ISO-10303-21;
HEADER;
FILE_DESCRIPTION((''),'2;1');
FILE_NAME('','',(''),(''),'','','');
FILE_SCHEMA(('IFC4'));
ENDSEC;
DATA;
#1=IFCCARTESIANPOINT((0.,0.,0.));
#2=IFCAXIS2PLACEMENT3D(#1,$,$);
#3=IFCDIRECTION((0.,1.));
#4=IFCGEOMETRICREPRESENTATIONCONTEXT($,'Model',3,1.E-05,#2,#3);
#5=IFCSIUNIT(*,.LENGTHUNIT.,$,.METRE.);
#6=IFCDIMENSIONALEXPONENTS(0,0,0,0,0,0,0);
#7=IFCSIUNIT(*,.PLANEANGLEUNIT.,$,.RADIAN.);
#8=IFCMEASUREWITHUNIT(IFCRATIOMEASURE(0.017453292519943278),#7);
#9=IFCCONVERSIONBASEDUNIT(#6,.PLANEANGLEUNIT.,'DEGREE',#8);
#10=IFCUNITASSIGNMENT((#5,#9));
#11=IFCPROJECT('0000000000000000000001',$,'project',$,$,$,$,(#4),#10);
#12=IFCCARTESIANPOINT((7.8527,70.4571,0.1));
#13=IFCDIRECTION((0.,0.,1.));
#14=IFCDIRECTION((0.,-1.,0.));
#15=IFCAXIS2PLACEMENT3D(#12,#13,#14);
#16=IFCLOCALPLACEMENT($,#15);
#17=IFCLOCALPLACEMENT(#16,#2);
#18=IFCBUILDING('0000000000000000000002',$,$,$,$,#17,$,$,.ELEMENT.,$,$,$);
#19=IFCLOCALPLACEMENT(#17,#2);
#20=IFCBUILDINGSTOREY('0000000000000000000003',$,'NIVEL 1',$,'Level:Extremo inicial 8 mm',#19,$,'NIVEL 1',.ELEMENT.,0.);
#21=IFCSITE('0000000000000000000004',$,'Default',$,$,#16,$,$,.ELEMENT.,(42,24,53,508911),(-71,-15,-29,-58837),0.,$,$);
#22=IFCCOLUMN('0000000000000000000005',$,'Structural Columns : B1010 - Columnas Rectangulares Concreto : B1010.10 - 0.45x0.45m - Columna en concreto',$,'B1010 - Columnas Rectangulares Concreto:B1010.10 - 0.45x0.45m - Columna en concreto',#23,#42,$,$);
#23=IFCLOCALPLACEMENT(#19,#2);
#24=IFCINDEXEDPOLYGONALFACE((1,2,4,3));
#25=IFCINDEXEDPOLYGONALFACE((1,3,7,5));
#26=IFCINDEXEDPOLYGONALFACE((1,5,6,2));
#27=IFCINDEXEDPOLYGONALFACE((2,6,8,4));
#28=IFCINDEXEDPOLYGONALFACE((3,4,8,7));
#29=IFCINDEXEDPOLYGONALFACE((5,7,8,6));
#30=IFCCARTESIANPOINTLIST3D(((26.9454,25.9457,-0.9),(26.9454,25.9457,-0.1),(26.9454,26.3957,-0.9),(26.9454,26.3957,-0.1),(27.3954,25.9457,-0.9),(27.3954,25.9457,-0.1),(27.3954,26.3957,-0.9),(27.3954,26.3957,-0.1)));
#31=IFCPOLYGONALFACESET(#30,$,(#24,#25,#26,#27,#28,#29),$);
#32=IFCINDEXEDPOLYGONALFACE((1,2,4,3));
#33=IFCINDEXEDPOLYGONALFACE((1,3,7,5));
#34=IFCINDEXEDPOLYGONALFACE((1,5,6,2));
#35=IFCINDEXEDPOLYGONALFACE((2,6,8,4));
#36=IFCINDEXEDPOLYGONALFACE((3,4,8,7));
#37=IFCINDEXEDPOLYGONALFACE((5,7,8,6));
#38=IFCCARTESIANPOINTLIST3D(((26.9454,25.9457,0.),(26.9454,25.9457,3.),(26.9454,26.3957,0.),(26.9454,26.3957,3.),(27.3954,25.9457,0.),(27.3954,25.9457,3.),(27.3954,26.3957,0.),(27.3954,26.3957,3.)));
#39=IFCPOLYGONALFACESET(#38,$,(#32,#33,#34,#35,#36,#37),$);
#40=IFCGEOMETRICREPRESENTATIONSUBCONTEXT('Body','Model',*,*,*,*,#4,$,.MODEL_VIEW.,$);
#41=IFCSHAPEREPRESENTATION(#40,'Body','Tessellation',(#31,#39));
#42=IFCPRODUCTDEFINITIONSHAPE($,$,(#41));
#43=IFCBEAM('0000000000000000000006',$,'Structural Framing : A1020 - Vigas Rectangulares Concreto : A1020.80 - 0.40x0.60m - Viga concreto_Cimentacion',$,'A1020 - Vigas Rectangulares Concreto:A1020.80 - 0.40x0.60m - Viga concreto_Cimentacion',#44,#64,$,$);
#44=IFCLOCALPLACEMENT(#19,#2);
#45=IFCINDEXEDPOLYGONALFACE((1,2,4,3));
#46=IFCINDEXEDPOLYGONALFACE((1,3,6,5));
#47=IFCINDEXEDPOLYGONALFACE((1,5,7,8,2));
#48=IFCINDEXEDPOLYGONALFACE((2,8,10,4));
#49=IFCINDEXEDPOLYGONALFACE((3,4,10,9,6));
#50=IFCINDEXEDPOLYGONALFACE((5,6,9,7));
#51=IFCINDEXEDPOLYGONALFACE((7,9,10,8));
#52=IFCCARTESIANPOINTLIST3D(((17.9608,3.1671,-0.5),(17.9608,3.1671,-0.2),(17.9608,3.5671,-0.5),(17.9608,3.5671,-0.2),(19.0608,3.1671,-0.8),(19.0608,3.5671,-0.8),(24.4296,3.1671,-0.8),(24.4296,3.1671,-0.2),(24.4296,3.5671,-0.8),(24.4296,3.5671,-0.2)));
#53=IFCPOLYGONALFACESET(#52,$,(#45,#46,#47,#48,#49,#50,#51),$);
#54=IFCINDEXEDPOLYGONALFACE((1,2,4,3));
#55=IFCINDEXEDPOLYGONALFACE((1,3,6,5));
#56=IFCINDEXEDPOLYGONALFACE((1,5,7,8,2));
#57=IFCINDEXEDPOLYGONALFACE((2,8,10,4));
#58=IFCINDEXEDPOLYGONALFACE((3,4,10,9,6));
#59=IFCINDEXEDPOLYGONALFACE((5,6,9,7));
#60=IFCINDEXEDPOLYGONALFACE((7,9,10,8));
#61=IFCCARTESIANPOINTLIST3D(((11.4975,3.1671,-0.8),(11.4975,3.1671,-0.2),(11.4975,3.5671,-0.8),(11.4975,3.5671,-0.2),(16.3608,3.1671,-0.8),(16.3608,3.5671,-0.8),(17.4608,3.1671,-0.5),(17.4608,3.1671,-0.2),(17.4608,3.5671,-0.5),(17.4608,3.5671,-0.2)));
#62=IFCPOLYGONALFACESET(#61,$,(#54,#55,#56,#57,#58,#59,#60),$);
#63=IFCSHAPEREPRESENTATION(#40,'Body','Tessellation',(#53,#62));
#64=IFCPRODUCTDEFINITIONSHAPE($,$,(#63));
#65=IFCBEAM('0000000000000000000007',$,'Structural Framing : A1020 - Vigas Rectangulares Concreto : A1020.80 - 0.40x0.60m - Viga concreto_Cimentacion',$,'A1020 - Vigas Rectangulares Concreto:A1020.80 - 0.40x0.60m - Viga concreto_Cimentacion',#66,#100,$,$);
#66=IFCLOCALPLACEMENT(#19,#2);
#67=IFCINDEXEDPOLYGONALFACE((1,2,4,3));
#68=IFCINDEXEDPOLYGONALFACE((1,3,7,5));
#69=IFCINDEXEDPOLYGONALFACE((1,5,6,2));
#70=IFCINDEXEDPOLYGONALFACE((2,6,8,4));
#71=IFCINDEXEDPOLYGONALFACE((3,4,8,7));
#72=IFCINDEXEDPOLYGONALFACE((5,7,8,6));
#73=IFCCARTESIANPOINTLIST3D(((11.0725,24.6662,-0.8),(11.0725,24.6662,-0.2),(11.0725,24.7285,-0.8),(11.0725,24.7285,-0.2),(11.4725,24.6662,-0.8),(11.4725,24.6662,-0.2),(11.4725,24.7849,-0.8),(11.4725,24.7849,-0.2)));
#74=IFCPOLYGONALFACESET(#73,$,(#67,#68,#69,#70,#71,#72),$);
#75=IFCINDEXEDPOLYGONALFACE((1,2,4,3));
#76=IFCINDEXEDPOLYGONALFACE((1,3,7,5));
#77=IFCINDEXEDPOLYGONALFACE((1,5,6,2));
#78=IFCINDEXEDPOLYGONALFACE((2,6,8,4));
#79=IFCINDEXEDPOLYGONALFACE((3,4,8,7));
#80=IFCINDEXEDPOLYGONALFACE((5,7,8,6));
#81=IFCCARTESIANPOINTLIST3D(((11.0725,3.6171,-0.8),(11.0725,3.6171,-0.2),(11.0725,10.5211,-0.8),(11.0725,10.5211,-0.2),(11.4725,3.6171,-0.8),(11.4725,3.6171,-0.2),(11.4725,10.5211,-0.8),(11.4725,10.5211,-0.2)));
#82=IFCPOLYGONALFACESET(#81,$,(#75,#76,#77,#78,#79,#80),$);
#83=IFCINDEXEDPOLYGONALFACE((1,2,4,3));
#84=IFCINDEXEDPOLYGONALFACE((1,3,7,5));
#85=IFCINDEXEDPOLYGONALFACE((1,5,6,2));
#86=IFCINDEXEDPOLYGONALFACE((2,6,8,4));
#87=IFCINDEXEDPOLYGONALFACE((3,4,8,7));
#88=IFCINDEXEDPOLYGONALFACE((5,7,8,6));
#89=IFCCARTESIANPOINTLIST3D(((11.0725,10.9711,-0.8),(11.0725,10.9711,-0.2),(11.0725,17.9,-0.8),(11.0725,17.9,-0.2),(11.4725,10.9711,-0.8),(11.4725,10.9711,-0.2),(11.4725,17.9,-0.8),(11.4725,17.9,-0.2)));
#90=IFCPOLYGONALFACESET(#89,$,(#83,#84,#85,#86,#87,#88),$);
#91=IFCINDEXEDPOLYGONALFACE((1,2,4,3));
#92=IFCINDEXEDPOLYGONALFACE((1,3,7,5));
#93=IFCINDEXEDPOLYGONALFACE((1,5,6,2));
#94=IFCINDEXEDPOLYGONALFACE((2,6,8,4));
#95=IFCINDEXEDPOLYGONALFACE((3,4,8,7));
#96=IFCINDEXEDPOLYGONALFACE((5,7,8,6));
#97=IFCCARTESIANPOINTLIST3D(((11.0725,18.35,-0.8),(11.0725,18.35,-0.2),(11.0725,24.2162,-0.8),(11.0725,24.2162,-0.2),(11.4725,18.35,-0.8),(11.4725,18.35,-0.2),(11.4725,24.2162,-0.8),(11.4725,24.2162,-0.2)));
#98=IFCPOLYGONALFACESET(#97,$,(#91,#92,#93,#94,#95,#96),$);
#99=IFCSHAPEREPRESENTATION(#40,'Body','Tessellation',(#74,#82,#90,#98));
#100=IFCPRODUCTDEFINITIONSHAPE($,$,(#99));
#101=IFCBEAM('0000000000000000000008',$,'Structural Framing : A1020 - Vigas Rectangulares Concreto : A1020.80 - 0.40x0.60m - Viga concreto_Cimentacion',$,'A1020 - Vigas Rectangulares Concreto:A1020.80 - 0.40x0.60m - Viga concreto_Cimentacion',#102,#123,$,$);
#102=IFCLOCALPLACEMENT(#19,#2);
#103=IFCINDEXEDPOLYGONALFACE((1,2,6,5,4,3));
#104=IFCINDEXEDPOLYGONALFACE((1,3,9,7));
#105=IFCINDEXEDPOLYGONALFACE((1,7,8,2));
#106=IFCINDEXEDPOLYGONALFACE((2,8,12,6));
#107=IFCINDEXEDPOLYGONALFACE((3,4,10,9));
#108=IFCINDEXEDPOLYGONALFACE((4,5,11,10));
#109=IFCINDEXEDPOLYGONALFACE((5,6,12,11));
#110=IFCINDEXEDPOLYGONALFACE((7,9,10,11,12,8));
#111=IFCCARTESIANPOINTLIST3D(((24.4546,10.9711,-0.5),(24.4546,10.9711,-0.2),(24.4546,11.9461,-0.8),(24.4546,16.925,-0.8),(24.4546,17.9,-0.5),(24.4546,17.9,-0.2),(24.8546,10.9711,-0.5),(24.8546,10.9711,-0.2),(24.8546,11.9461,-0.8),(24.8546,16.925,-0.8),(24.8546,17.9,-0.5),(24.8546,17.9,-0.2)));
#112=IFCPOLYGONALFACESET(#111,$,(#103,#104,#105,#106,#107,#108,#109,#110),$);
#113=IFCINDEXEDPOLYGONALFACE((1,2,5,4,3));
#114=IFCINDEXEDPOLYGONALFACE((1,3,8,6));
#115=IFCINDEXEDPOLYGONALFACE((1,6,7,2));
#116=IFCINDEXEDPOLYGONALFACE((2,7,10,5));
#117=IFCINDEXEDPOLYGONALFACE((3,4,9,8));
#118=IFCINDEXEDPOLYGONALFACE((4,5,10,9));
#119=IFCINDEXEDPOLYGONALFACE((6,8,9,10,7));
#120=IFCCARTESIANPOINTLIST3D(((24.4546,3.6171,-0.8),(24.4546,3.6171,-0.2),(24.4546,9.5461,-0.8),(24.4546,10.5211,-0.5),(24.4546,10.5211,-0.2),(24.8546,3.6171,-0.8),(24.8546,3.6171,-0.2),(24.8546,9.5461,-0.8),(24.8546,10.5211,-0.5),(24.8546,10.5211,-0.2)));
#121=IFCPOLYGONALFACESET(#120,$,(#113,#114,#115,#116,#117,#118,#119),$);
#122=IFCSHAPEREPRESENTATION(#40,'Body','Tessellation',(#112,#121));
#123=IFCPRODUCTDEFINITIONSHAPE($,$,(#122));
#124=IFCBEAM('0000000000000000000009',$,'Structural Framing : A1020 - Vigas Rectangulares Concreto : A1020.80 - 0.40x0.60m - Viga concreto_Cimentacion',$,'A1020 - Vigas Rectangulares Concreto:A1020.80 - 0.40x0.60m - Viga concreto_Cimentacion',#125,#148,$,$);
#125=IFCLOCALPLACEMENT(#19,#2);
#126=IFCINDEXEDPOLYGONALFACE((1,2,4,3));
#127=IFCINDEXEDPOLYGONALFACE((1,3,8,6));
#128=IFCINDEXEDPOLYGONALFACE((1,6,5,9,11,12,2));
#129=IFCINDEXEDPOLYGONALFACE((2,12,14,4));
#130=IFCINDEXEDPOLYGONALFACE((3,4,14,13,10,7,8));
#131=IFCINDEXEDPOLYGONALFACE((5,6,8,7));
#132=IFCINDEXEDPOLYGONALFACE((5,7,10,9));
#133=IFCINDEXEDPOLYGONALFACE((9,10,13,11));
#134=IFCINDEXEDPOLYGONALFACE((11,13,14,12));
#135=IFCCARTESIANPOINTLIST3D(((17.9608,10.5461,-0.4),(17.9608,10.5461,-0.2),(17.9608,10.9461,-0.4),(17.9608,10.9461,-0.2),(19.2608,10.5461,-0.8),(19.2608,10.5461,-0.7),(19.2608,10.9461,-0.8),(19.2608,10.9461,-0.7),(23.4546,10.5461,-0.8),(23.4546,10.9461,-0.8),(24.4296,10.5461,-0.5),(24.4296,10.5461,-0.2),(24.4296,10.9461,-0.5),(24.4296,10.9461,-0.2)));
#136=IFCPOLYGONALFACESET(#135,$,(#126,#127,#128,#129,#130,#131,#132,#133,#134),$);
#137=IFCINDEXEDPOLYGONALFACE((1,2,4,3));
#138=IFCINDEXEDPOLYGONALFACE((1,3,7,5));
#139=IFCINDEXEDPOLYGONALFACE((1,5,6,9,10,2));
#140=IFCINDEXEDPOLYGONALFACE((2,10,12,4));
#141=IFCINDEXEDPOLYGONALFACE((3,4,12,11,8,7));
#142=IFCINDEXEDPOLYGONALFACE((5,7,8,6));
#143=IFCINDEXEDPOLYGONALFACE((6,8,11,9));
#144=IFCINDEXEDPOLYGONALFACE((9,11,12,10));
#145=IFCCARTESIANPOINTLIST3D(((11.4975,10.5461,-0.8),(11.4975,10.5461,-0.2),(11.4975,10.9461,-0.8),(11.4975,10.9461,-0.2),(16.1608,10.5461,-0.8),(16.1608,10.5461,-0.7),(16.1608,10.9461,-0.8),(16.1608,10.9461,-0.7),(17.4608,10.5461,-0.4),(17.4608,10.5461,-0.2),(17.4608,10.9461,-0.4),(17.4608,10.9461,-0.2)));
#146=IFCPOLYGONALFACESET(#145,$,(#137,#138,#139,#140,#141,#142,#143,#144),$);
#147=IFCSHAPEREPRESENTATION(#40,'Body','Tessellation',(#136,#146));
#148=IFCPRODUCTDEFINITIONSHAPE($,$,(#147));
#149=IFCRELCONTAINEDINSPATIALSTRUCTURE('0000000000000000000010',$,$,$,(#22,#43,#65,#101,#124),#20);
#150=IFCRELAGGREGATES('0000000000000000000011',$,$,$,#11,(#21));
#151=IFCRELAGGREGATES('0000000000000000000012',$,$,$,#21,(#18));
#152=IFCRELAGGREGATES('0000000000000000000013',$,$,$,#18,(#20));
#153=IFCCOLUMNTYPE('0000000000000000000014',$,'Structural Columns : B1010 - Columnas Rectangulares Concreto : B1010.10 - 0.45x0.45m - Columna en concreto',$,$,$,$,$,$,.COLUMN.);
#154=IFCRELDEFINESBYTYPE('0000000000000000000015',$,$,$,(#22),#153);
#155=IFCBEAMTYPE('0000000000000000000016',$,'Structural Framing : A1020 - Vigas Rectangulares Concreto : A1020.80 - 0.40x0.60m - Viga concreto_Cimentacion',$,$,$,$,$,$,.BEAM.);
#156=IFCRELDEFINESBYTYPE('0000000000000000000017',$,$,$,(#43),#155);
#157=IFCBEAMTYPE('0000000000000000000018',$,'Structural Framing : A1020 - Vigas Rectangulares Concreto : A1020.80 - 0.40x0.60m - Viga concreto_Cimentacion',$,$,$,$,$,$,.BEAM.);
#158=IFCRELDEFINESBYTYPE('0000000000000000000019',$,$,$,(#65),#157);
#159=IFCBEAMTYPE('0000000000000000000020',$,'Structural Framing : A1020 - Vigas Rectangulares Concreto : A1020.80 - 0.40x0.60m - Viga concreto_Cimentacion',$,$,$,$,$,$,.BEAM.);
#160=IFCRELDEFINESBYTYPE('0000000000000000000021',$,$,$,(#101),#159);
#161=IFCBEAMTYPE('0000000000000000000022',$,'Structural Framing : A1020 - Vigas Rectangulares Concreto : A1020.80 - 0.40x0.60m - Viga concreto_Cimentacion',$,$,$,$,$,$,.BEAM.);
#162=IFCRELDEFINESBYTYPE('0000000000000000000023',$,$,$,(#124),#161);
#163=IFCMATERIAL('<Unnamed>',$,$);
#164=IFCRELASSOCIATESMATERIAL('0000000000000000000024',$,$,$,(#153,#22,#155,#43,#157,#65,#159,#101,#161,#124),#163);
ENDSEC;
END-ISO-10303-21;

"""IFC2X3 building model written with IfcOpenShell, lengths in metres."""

from ifc_helpers import new_model, entity, si_unit, converted_unit, direction, frame, frame_2d, origin, origin_2d_with_axis, place, context, subcontext, project, spatial, polyline, rectangle, extrude, clip, halfspace, bounded_halfspace, source, transform, mapped, material, type_object, type_shapes, element, save


model = new_model("IFC2X3")

# Units and contexts
model_context = context("Model", 3, precision=1e-05, world=origin(), true_north=direction((0.0, 1.0)))
body_context = subcontext(model_context, "Body", "Model", "MODEL_VIEW")
ifc_project = project(units=[si_unit("LENGTHUNIT", "METRE"), converted_unit("PLANEANGLEUNIT", "DEGREE", entity("IfcRatioMeasure", 0.017453292519943278), si_unit("PLANEANGLEUNIT", "RADIAN"), dimensions=[0, 0, 0, 0, 0, 0, 0])], contexts=[model_context])

# Site, building, storey
site_placement = place(None, frame((7.8527, 70.4571, 0.1), z_axis=(0.0, 0.0, 1.0), x_axis=(0.0, -1.0, 0.0)))
site = spatial("IfcSite", under=ifc_project, at=site_placement, Name="Default", CompositionType="ELEMENT", RefLatitude=(42, 24, 53, 508911), RefLongitude=(-71, -15, -29, -58837), RefElevation=0.0)
building_placement = place(site_placement, origin())
building = spatial("IfcBuilding", under=site, at=building_placement, CompositionType="ELEMENT")
storey_placement = place(building_placement, origin())
storey = spatial("IfcBuildingStorey", under=building, at=storey_placement, Name="NIVEL 1", ObjectType="Level:Extremo inicial 8 mm", LongName="NIVEL 1", CompositionType="ELEMENT", Elevation=0.0)

# Column
ifc_material_1 = material(Name="<Unnamed>")
column_type = type_object("IfcColumnType", Name="Structural Columns : B1010 - Columnas Rectangulares Concreto : B1010.10 - 0.45x0.45m - Columna en concreto", PredefinedType="COLUMN", material=ifc_material_1)
shared_shape_1 = source(origin(), body_context, "Body", "SweptSolid", [
    extrude(rectangle(XDim=0.45, YDim=0.45, at=origin_2d_with_axis()), frame((27.1704, 26.1707, -0.9), z_axis=(0.0, 0.0, 1.0), x_axis=(0.0, -1.0, 0.0)), (0.0, 0.0, 1.0), 0.8),
    extrude(rectangle(XDim=0.45, YDim=0.45, at=origin_2d_with_axis()), frame((27.1704, 26.1707, 0.0), z_axis=(0.0, 0.0, 1.0), x_axis=(0.0, -1.0, 0.0)), (0.0, 0.0, 1.0), 3.0),
])
type_shapes(column_type, [shared_shape_1])
column_placement = place(storey_placement, origin())
element("IfcColumn", 1, at=column_placement, inside=storey, type_object=column_type, material=ifc_material_1, Name="Structural Columns : B1010 - Columnas Rectangulares Concreto : B1010.10 - 0.45x0.45m - Columna en concreto", ObjectType="B1010 - Columnas Rectangulares Concreto:B1010.10 - 0.45x0.45m - Columna en concreto", context=body_context, shape_type="MappedRepresentation", body=[
    mapped(shared_shape_1, transform((0.0, 0.0, 0.0), scale=1.0)),
])

# Beams
beam_type_1 = type_object("IfcBeamType", Name="Structural Framing : A1020 - Vigas Rectangulares Concreto : A1020.80 - 0.40x0.60m - Viga concreto_Cimentacion", PredefinedType="BEAM", material=ifc_material_1)
shared_shape_2 = source(origin(), body_context, "Body", "SweptSolid", [
    clip(extrude(rectangle(XDim=0.6, YDim=0.4, at=frame_2d((0.0, 0.0), x_axis=(0.0, 1.0))), frame((17.9608, 3.3671, -0.5), z_axis=(1.0, 0.0, 0.0), x_axis=(0.0, 1.0, 0.0)), (0.0, 0.0, 1.0), 6.4688), halfspace(frame((19.0608, 3.3671, -0.8), z_axis=(-0.263117, 0.0, -0.964764), x_axis=(0.0, 1.0, 0.0)), False)),
    clip(extrude(rectangle(XDim=0.6, YDim=0.4, at=frame_2d((0.0, 0.0), x_axis=(0.0, 1.0))), frame((11.4975, 3.3671, -0.5), z_axis=(1.0, 0.0, 0.0), x_axis=(0.0, 1.0, 0.0)), (0.0, 0.0, 1.0), 5.9633), halfspace(frame((16.3608, 3.3671, -0.8), z_axis=(0.263117, 0.0, -0.964764), x_axis=(0.0, -1.0, 0.0)), False)),
])
type_shapes(beam_type_1, [shared_shape_2])
beam_1_placement = place(storey_placement, origin())
element("IfcBeam", 2, at=beam_1_placement, inside=storey, type_object=beam_type_1, material=ifc_material_1, Name="Structural Framing : A1020 - Vigas Rectangulares Concreto : A1020.80 - 0.40x0.60m - Viga concreto_Cimentacion", ObjectType="A1020 - Vigas Rectangulares Concreto:A1020.80 - 0.40x0.60m - Viga concreto_Cimentacion", context=body_context, shape_type="MappedRepresentation", body=[
    mapped(shared_shape_2, transform((0.0, 0.0, 0.0), scale=1.0)),
])
beam_type_2 = type_object("IfcBeamType", Name="Structural Framing : A1020 - Vigas Rectangulares Concreto : A1020.80 - 0.40x0.60m - Viga concreto_Cimentacion", PredefinedType="BEAM", material=ifc_material_1)
shared_shape_3 = source(origin(), body_context, "Body", "SweptSolid", [
    clip(extrude(rectangle(XDim=0.6, YDim=0.4, at=frame_2d((0.0, 0.0), x_axis=(0.0, 1.0))), frame((11.2725, 24.6662, -0.5), z_axis=(0.0, 1.0, 0.0), x_axis=(-1.0, 0.0, 0.0)), (0.0, 0.0, 1.0), 0.1187), halfspace(frame((10.9962, 24.7178, -0.2), z_axis=(-0.139655, 0.9902, 0.0), x_axis=(0.9902, 0.139655, 0.0)), False)),
    extrude(rectangle(XDim=0.6, YDim=0.4, at=frame_2d((0.0, 0.0), x_axis=(0.0, 1.0))), frame((11.2725, 3.6171, -0.5), z_axis=(0.0, 1.0, 0.0), x_axis=(-1.0, 0.0, 0.0)), (0.0, 0.0, 1.0), 6.904),
    extrude(rectangle(XDim=0.6, YDim=0.4, at=frame_2d((0.0, 0.0), x_axis=(0.0, 1.0))), frame((11.2725, 10.9711, -0.5), z_axis=(0.0, 1.0, 0.0), x_axis=(-1.0, 0.0, 0.0)), (0.0, 0.0, 1.0), 6.929),
    extrude(rectangle(XDim=0.6, YDim=0.4, at=frame_2d((0.0, 0.0), x_axis=(0.0, 1.0))), frame((11.2725, 18.35, -0.5), z_axis=(0.0, 1.0, 0.0), x_axis=(-1.0, 0.0, 0.0)), (0.0, 0.0, 1.0), 5.8662),
])
type_shapes(beam_type_2, [shared_shape_3])
beam_2_placement = place(storey_placement, origin())
element("IfcBeam", 3, at=beam_2_placement, inside=storey, type_object=beam_type_2, material=ifc_material_1, Name="Structural Framing : A1020 - Vigas Rectangulares Concreto : A1020.80 - 0.40x0.60m - Viga concreto_Cimentacion", ObjectType="A1020 - Vigas Rectangulares Concreto:A1020.80 - 0.40x0.60m - Viga concreto_Cimentacion", context=body_context, shape_type="MappedRepresentation", body=[
    mapped(shared_shape_3, transform((0.0, 0.0, 0.0), scale=1.0)),
])
beam_type_3 = type_object("IfcBeamType", Name="Structural Framing : A1020 - Vigas Rectangulares Concreto : A1020.80 - 0.40x0.60m - Viga concreto_Cimentacion", PredefinedType="BEAM", material=ifc_material_1)
shared_shape_4 = source(origin(), body_context, "Body", "SweptSolid", [
    clip(clip(extrude(rectangle(XDim=0.6, YDim=0.4, at=frame_2d((0.0, 0.0), x_axis=(0.0, 1.0))), frame((24.6546, 10.9711, -0.5), z_axis=(0.0, 1.0, 0.0), x_axis=(-1.0, 0.0, 0.0)), (0.0, 0.0, 1.0), 6.929), halfspace(frame((24.6546, 11.9461, -0.8), z_axis=(0.0, -0.294086, -0.955779), x_axis=(-1.0, 0.0, 0.0)), False)), halfspace(frame((24.6546, 16.925, -0.8), z_axis=(0.0, 0.294086, -0.955779), x_axis=(1.0, 0.0, 0.0)), False)),
    clip(extrude(rectangle(XDim=0.6, YDim=0.4, at=frame_2d((0.0, 0.0), x_axis=(0.0, 1.0))), frame((24.6546, 3.6171, -0.5), z_axis=(0.0, 1.0, 0.0), x_axis=(-1.0, 0.0, 0.0)), (0.0, 0.0, 1.0), 6.904), halfspace(frame((24.6546, 9.5461, -0.8), z_axis=(0.0, 0.294086, -0.955779), x_axis=(1.0, 0.0, 0.0)), False)),
])
type_shapes(beam_type_3, [shared_shape_4])
beam_3_placement = place(storey_placement, origin())
element("IfcBeam", 4, at=beam_3_placement, inside=storey, type_object=beam_type_3, material=ifc_material_1, Name="Structural Framing : A1020 - Vigas Rectangulares Concreto : A1020.80 - 0.40x0.60m - Viga concreto_Cimentacion", ObjectType="A1020 - Vigas Rectangulares Concreto:A1020.80 - 0.40x0.60m - Viga concreto_Cimentacion", context=body_context, shape_type="MappedRepresentation", body=[
    mapped(shared_shape_4, transform((0.0, 0.0, 0.0), scale=1.0)),
])
beam_type_4 = type_object("IfcBeamType", Name="Structural Framing : A1020 - Vigas Rectangulares Concreto : A1020.80 - 0.40x0.60m - Viga concreto_Cimentacion", PredefinedType="BEAM", material=ifc_material_1)
shared_shape_5 = source(origin(), body_context, "Body", "SweptSolid", [
    clip(clip(clip(extrude(rectangle(XDim=0.6, YDim=0.4, at=frame_2d((0.0, 0.0), x_axis=(0.0, 1.0))), frame((17.9608, 10.7461, -0.5), z_axis=(1.0, 0.0, 0.0), x_axis=(0.0, 1.0, 0.0)), (0.0, 0.0, 1.0), 6.4688), halfspace(frame((23.4546, 10.7461, -0.8), z_axis=(0.294086, 0.0, -0.955779), x_axis=(0.0, -1.0, 0.0)), False)), bounded_halfspace(frame((19.2608, 10.7461, -0.7), z_axis=(-0.22486, 0.0, -0.974391), x_axis=(0.0, 1.0, 0.0)), False, frame((17.9608, 10.7461, -0.5), z_axis=(1.0, 0.0, 0.0), x_axis=(0.0, 1.0, 0.0)), polyline([(-0.2, -0.2), (-0.2, 0.1), (0.2, 0.1), (0.2, -0.2), (-0.2, -0.2)]))), bounded_halfspace(frame((19.2608, 9.1961, -0.7), z_axis=(-1.0, 0.0, 0.0), x_axis=(0.0, 0.0, -1.0)), False, frame((17.9608, 10.7461, -0.5), z_axis=(1.0, 0.0, 0.0), x_axis=(0.0, 1.0, 0.0)), polyline([(-0.2, -0.3), (-0.2, -0.2), (0.2, -0.2), (0.2, -0.3), (-0.2, -0.3)]))),
    clip(clip(extrude(rectangle(XDim=0.6, YDim=0.4, at=frame_2d((0.0, 0.0), x_axis=(0.0, 1.0))), frame((11.4975, 10.7461, -0.5), z_axis=(1.0, 0.0, 0.0), x_axis=(0.0, 1.0, 0.0)), (0.0, 0.0, 1.0), 5.9633), bounded_halfspace(frame((16.1608, 10.7461, -0.7), z_axis=(0.22486, 0.0, -0.974391), x_axis=(0.0, -1.0, 0.0)), False, frame((11.4975, 10.7461, -0.5), z_axis=(1.0, 0.0, 0.0), x_axis=(0.0, 1.0, 0.0)), polyline([(-0.2, 0.1), (-0.2, -0.2), (0.2, -0.2), (0.2, 0.1), (-0.2, 0.1)]))), bounded_halfspace(frame((16.1608, 12.2961, -0.7), z_axis=(1.0, 0.0, 0.0), x_axis=(0.0, 0.0, -1.0)), False, frame((11.4975, 10.7461, -0.5), z_axis=(1.0, 0.0, 0.0), x_axis=(0.0, 1.0, 0.0)), polyline([(-0.2, -0.2), (-0.2, -0.3), (0.2, -0.3), (0.2, -0.2), (-0.2, -0.2)]))),
])
type_shapes(beam_type_4, [shared_shape_5])
beam_4_placement = place(storey_placement, origin())
element("IfcBeam", 5, at=beam_4_placement, inside=storey, type_object=beam_type_4, material=ifc_material_1, Name="Structural Framing : A1020 - Vigas Rectangulares Concreto : A1020.80 - 0.40x0.60m - Viga concreto_Cimentacion", ObjectType="A1020 - Vigas Rectangulares Concreto:A1020.80 - 0.40x0.60m - Viga concreto_Cimentacion", context=body_context, shape_type="MappedRepresentation", body=[
    mapped(shared_shape_5, transform((0.0, 0.0, 0.0), scale=1.0)),
])

save(model, "model.ifc")
